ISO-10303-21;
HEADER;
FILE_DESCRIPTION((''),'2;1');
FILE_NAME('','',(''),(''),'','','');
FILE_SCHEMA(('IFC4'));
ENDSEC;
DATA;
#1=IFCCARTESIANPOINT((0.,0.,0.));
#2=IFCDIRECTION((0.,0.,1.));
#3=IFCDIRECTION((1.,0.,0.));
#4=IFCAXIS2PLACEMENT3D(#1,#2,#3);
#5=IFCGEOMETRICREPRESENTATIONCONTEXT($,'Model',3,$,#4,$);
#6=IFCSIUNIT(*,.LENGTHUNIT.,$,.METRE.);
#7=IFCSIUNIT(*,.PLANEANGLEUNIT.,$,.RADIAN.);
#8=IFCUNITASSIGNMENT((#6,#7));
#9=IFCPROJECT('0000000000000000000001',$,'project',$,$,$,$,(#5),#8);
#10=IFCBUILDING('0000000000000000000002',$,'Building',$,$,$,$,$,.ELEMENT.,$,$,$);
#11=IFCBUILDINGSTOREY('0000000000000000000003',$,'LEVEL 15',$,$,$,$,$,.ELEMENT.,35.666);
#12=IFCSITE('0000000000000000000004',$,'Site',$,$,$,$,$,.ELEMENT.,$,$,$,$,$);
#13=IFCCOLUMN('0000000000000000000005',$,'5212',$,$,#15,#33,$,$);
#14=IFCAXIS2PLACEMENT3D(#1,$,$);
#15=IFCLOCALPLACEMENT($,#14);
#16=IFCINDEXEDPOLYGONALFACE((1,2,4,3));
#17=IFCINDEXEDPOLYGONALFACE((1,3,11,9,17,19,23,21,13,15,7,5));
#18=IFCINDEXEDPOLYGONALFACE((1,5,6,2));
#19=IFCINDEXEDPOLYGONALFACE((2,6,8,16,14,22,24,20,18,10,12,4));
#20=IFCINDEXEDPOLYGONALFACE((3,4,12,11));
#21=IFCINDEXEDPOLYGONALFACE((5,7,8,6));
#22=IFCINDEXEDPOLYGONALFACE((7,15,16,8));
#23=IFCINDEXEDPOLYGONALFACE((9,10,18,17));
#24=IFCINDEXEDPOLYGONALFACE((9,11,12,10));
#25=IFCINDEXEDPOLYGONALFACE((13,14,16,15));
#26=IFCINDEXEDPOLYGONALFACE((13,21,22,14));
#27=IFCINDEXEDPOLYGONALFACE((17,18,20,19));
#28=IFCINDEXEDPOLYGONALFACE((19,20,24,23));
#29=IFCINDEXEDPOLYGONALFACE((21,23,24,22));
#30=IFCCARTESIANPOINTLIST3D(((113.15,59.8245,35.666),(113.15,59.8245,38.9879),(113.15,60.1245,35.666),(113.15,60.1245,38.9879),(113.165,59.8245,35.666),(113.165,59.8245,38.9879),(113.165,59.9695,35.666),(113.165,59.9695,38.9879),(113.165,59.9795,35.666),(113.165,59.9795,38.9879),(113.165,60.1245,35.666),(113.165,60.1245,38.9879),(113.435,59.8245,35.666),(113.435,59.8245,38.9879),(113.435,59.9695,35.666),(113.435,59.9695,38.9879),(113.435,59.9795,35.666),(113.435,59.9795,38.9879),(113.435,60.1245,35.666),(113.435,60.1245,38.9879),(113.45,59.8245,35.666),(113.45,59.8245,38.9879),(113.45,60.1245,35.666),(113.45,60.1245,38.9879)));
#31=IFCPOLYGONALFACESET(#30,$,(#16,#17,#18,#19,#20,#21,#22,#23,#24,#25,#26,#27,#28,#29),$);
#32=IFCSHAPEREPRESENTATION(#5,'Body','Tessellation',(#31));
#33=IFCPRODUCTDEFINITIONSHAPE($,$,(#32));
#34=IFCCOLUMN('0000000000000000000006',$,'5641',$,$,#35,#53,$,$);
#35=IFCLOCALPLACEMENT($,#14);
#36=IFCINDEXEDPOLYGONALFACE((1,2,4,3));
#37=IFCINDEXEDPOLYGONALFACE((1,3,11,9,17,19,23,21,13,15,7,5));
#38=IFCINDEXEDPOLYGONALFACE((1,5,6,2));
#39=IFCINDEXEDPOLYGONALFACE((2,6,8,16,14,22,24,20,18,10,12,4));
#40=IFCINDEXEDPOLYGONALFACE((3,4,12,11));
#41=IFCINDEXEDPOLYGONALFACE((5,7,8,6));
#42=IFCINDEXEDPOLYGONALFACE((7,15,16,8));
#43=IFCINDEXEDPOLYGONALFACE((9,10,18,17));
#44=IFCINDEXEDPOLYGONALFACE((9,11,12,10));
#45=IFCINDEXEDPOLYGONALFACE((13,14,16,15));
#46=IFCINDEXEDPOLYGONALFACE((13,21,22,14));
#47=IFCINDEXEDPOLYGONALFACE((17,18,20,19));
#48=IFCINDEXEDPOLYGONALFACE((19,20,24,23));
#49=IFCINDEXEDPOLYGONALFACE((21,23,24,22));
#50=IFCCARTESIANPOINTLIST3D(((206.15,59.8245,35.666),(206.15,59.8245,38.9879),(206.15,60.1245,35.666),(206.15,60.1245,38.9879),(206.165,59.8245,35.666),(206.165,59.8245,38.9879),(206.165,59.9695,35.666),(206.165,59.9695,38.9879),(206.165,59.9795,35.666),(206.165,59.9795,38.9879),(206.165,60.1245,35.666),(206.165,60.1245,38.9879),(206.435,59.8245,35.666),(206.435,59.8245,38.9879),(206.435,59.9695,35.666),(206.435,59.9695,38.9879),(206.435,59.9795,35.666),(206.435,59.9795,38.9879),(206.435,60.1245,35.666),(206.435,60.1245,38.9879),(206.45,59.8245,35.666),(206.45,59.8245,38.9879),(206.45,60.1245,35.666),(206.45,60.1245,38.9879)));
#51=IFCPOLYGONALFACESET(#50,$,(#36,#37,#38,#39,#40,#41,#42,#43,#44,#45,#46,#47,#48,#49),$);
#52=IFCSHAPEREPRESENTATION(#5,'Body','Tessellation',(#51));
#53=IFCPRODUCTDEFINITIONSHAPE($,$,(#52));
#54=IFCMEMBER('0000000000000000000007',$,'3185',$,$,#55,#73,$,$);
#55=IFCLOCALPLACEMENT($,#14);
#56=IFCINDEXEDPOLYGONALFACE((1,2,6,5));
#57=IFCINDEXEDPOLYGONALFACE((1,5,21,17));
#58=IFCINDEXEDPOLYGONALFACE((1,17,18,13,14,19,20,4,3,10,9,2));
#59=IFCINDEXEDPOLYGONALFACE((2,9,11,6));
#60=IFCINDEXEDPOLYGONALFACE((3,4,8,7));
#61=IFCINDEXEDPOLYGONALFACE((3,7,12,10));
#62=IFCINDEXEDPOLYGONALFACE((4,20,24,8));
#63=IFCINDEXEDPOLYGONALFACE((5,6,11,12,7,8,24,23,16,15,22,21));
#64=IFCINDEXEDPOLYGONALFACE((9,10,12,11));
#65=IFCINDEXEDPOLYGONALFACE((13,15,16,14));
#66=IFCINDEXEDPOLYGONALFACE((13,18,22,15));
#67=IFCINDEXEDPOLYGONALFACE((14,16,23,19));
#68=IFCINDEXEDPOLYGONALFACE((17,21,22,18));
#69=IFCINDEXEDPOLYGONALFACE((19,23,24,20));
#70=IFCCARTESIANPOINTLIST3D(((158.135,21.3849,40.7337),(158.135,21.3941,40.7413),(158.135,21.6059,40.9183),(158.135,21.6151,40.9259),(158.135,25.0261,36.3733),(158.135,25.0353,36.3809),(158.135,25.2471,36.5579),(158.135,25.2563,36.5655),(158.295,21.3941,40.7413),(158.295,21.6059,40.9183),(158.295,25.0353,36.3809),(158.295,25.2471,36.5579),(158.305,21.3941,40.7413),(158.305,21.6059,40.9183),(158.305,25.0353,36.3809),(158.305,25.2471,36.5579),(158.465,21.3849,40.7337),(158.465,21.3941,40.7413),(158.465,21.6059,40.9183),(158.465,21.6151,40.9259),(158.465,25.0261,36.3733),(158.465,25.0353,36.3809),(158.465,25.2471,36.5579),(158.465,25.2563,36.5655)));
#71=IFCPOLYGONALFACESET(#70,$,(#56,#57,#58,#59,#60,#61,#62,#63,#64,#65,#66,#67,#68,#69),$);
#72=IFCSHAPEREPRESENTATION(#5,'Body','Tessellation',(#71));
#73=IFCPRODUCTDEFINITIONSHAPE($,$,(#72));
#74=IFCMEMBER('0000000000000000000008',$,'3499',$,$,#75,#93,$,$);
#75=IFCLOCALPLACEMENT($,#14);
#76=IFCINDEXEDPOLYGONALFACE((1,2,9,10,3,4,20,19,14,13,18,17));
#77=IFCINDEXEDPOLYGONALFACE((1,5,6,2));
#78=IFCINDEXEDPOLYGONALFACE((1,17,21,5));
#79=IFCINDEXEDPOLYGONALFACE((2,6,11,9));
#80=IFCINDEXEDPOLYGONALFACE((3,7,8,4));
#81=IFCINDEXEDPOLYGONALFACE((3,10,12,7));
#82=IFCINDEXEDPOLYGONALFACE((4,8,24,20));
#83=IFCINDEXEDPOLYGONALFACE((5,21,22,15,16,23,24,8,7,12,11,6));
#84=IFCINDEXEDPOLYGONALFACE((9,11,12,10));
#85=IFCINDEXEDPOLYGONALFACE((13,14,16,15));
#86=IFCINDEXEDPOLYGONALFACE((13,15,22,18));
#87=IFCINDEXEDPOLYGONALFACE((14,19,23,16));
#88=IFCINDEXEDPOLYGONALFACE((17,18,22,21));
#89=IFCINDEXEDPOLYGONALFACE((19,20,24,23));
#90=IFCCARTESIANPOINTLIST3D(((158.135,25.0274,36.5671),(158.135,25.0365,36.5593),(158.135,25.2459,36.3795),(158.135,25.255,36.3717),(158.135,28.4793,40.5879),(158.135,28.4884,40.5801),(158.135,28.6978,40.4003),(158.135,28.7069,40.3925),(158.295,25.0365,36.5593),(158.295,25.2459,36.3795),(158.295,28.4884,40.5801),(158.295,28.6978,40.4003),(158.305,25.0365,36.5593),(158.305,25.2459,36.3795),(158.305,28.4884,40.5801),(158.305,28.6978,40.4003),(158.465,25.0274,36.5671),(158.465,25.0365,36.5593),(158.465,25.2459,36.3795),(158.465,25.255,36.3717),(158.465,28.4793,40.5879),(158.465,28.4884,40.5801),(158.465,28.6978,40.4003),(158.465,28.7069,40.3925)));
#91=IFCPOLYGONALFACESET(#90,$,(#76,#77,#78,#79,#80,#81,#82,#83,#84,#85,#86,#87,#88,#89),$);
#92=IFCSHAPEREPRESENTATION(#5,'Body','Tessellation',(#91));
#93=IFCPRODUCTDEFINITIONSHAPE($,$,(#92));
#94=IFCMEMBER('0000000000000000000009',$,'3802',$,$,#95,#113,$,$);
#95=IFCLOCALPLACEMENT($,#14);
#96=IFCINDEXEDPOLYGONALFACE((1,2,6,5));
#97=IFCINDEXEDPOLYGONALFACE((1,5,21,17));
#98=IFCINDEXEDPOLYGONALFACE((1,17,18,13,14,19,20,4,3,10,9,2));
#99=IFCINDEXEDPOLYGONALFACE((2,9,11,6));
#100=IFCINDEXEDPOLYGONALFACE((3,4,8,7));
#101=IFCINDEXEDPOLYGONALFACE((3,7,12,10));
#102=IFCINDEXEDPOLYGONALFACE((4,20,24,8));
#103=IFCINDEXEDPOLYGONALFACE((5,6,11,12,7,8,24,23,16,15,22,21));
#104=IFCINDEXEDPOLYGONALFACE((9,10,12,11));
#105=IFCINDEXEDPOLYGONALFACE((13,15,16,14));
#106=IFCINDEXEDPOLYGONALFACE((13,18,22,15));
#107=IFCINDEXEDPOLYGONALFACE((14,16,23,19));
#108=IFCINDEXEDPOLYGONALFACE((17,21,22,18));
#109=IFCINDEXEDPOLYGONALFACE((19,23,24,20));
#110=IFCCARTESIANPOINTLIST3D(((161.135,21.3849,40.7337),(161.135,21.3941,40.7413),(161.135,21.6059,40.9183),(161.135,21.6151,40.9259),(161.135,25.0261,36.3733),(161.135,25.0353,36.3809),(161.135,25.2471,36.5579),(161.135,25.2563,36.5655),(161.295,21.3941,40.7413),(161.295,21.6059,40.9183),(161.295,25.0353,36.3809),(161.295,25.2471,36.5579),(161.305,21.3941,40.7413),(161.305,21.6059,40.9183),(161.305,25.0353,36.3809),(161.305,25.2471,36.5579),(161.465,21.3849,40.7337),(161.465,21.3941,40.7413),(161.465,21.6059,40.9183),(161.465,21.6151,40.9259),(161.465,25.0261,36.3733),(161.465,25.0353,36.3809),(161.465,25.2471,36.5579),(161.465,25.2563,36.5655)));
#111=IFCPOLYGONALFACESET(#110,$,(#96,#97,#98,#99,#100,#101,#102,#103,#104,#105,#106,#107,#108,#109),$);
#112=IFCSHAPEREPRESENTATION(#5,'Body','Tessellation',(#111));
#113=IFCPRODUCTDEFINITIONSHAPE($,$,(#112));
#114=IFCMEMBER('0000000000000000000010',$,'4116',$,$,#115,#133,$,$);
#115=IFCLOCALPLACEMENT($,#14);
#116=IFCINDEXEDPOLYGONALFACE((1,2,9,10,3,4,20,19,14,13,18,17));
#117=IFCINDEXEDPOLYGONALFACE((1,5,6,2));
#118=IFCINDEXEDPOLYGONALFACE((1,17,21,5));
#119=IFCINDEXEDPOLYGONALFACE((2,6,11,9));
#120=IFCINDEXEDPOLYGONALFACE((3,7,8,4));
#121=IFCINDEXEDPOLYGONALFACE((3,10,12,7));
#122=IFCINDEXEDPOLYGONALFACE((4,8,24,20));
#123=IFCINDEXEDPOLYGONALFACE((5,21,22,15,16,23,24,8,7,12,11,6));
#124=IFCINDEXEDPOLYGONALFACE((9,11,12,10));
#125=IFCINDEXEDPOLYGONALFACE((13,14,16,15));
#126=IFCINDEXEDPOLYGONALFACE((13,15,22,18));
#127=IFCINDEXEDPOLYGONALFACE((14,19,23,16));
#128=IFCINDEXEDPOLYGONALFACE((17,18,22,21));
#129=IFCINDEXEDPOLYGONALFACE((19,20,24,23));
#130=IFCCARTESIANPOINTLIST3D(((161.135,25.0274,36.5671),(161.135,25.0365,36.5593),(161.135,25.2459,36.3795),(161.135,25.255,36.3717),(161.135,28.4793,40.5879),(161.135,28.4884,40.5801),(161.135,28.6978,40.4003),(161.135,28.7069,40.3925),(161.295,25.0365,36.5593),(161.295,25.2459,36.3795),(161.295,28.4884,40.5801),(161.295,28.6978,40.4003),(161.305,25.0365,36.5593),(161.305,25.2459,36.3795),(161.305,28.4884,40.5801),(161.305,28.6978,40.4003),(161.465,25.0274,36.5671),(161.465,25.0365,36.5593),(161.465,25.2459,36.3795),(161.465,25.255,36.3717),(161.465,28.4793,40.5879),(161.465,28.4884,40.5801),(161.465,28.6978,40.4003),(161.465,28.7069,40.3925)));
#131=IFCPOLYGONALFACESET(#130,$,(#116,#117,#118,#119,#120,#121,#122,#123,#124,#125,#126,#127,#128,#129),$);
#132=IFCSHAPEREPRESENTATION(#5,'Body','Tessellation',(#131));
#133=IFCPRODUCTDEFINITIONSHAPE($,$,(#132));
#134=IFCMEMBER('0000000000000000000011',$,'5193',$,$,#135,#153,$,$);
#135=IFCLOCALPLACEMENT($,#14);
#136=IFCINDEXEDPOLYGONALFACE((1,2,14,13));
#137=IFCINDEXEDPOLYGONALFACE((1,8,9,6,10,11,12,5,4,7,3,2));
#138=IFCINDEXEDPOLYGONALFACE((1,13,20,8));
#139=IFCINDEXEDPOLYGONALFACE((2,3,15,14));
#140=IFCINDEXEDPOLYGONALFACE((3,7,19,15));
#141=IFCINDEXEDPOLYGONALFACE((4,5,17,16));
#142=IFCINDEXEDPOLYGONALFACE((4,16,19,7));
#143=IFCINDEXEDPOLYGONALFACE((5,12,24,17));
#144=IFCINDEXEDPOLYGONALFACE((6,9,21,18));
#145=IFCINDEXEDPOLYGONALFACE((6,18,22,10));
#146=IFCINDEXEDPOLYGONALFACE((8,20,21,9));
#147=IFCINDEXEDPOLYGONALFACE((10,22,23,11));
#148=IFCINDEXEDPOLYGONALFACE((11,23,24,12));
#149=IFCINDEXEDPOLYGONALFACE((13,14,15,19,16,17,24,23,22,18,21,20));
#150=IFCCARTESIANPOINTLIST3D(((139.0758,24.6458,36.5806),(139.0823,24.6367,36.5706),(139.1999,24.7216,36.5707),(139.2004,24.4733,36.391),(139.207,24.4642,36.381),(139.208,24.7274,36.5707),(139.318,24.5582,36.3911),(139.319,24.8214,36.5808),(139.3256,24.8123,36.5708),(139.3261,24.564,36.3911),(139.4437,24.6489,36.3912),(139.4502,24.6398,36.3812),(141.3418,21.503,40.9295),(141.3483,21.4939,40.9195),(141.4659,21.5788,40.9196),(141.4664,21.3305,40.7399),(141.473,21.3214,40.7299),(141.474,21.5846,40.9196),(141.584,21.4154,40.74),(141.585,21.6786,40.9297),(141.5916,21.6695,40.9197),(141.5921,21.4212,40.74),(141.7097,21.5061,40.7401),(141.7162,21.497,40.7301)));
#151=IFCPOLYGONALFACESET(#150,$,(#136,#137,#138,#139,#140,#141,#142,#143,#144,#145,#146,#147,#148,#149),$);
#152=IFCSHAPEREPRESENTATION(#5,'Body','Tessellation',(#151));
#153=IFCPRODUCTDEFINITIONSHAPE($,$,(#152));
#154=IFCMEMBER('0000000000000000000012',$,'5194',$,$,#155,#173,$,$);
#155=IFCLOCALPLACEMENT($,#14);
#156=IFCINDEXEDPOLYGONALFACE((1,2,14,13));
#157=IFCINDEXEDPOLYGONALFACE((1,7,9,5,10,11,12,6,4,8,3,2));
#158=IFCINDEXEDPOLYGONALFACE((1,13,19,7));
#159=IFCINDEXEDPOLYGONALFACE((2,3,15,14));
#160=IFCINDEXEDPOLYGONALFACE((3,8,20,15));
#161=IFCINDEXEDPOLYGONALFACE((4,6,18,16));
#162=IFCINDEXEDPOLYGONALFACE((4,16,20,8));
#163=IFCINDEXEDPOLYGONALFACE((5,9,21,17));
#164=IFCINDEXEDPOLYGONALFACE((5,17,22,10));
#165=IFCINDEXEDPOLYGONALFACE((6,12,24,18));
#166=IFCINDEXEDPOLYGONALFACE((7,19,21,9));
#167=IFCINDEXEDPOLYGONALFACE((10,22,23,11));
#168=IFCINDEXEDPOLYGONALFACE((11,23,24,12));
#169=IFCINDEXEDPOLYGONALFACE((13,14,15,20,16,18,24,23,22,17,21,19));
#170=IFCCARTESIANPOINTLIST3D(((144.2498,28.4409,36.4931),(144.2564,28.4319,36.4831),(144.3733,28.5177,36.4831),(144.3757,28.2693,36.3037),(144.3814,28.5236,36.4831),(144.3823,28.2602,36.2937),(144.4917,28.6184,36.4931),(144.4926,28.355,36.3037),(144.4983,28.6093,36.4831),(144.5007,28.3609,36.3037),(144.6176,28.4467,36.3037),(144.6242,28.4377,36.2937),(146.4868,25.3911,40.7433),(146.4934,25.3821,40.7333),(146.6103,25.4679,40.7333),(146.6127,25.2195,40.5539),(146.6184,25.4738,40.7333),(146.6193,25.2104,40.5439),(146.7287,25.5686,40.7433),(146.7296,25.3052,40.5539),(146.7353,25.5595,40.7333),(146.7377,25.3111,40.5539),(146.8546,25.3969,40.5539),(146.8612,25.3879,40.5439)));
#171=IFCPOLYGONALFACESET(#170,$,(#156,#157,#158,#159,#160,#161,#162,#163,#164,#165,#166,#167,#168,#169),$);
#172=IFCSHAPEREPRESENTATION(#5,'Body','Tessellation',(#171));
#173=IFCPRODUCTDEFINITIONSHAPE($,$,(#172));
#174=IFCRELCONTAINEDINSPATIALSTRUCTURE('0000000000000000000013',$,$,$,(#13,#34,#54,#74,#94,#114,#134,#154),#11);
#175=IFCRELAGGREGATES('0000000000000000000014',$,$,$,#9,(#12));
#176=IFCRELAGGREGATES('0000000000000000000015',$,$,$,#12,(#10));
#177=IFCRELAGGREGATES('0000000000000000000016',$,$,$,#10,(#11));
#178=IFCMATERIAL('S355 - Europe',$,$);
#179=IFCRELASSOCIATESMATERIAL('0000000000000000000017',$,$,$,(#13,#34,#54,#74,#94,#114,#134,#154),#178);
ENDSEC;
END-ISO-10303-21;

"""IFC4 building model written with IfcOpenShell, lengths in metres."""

from ifc_helpers import new_model, si_unit, frame, origin_with_axes, origin_2d_with_axis, place, context, project, spatial, i_section, extrude, material, material_profile, profile_set, profile_usage, element, save


model = new_model("IFC4")

# Units and contexts
model_context = context("Model", 3, world=origin_with_axes())
ifc_project = project(units=[si_unit("LENGTHUNIT", "METRE"), si_unit("PLANEANGLEUNIT", "RADIAN")], contexts=[model_context])

# Site, building, storey
site = spatial("IfcSite", under=ifc_project, Name="Site", CompositionType="ELEMENT")
building = spatial("IfcBuilding", under=site, Name="Building", CompositionType="ELEMENT")
storey = spatial("IfcBuildingStorey", under=building, Name="LEVEL 15", CompositionType="ELEMENT", Elevation=35.666)

# Columns
ifc_material = material(Name="S355 - Europe")
ifc_material_profile_1 = material_profile(ifc_material, i_section(OverallWidth=0.3, OverallDepth=0.3, WebThickness=0.01, FlangeThickness=0.015, at=origin_2d_with_axis()))
ifc_profile_set_1 = profile_set([ifc_material_profile_1])
ifc_profile_usage_1 = profile_usage(ifc_profile_set_1, cardinal=10)
column_1_placement = place(None, frame((113.3, 59.9745, 35.666), z_axis=(0.0, 0.0, 1.0), x_axis=(0.0, -1.0, 0.0)))
element("IfcColumn", 1, at=column_1_placement, inside=storey, material=ifc_profile_usage_1, Name="5212", context=model_context, shape_type="SweptSolid", body=[
    extrude(i_section(OverallWidth=0.3, OverallDepth=0.3, WebThickness=0.01, FlangeThickness=0.015, at=origin_2d_with_axis()), origin_with_axes(), (0.0, 0.0, 1.0), 3.3219),
])
ifc_material_profile_2 = material_profile(ifc_material, i_section(OverallWidth=0.3, OverallDepth=0.3, WebThickness=0.01, FlangeThickness=0.015, at=origin_2d_with_axis()))
ifc_profile_set_2 = profile_set([ifc_material_profile_2])
ifc_profile_usage_2 = profile_usage(ifc_profile_set_2, cardinal=10)
column_2_placement = place(None, frame((206.3, 59.9745, 35.666), z_axis=(0.0, 0.0, 1.0), x_axis=(0.0, -1.0, 0.0)))
element("IfcColumn", 2, at=column_2_placement, inside=storey, material=ifc_profile_usage_2, Name="5641", context=model_context, shape_type="SweptSolid", body=[
    extrude(i_section(OverallWidth=0.3, OverallDepth=0.3, WebThickness=0.01, FlangeThickness=0.015, at=origin_2d_with_axis()), origin_with_axes(), (0.0, 0.0, 1.0), 3.3219),
])

# Members
ifc_material_profile_3 = material_profile(ifc_material, i_section(OverallWidth=0.33, OverallDepth=0.3, WebThickness=0.01, FlangeThickness=0.012, at=origin_2d_with_axis()))
ifc_profile_set_3 = profile_set([ifc_material_profile_3])
ifc_profile_usage_3 = profile_usage(ifc_profile_set_3, cardinal=10)
member_1_placement = place(None, frame((158.3, 21.5, 40.8298), z_axis=(0.0, 0.640967, -0.767569), x_axis=(-1.0, 0.0, 0.0)))
element("IfcMember", 3, at=member_1_placement, inside=storey, material=ifc_profile_usage_3, Name="3185", context=model_context, shape_type="SweptSolid", body=[
    extrude(i_section(OverallWidth=0.33, OverallDepth=0.3, WebThickness=0.01, FlangeThickness=0.012, at=origin_2d_with_axis()), origin_with_axes(), (0.0, 0.0, 1.0), 5.6808),
])
ifc_material_profile_4 = material_profile(ifc_material, i_section(OverallWidth=0.33, OverallDepth=0.3, WebThickness=0.01, FlangeThickness=0.012, at=origin_2d_with_axis()))
ifc_profile_set_4 = profile_set([ifc_material_profile_4])
ifc_profile_usage_4 = profile_usage(ifc_profile_set_4, cardinal=10)
member_2_placement = place(None, frame((158.3, 25.1412, 36.4694), z_axis=(0.0, 0.651389, 0.758744), x_axis=(-1.0, 0.0, 0.0)))
element("IfcMember", 4, at=member_2_placement, inside=storey, material=ifc_profile_usage_4, Name="3499", context=model_context, shape_type="SweptSolid", body=[
    extrude(i_section(OverallWidth=0.33, OverallDepth=0.3, WebThickness=0.01, FlangeThickness=0.012, at=origin_2d_with_axis()), origin_with_axes(), (0.0, 0.0, 1.0), 5.2993),
])
ifc_material_profile_5 = material_profile(ifc_material, i_section(OverallWidth=0.33, OverallDepth=0.3, WebThickness=0.01, FlangeThickness=0.012, at=origin_2d_with_axis()))
ifc_profile_set_5 = profile_set([ifc_material_profile_5])
ifc_profile_usage_5 = profile_usage(ifc_profile_set_5, cardinal=10)
member_3_placement = place(None, frame((161.3, 21.5, 40.8298), z_axis=(0.0, 0.640967, -0.767569), x_axis=(-1.0, 0.0, 0.0)))
element("IfcMember", 5, at=member_3_placement, inside=storey, material=ifc_profile_usage_5, Name="3802", context=model_context, shape_type="SweptSolid", body=[
    extrude(i_section(OverallWidth=0.33, OverallDepth=0.3, WebThickness=0.01, FlangeThickness=0.012, at=origin_2d_with_axis()), origin_with_axes(), (0.0, 0.0, 1.0), 5.6808),
])
ifc_material_profile_6 = material_profile(ifc_material, i_section(OverallWidth=0.33, OverallDepth=0.3, WebThickness=0.01, FlangeThickness=0.012, at=origin_2d_with_axis()))
ifc_profile_set_6 = profile_set([ifc_material_profile_6])
ifc_profile_usage_6 = profile_usage(ifc_profile_set_6, cardinal=10)
member_4_placement = place(None, frame((161.3, 25.1412, 36.4694), z_axis=(0.0, 0.651389, 0.758744), x_axis=(-1.0, 0.0, 0.0)))
element("IfcMember", 6, at=member_4_placement, inside=storey, material=ifc_profile_usage_6, Name="4116", context=model_context, shape_type="SweptSolid", body=[
    extrude(i_section(OverallWidth=0.33, OverallDepth=0.3, WebThickness=0.01, FlangeThickness=0.012, at=origin_2d_with_axis()), origin_with_axes(), (0.0, 0.0, 1.0), 5.2993),
])
ifc_material_profile_7 = material_profile(ifc_material, i_section(OverallWidth=0.3, OverallDepth=0.3, WebThickness=0.01, FlangeThickness=0.015, at=origin_2d_with_axis()))
ifc_profile_set_7 = profile_set([ifc_material_profile_7])
ifc_profile_usage_7 = profile_usage(ifc_profile_set_7, cardinal=10)
member_5_placement = place(None, frame((139.263, 24.6428, 36.4809), z_axis=(0.389046, -0.539582, 0.746656), x_axis=(0.810475, 0.585773, 0.0)))
element("IfcMember", 7, at=member_5_placement, inside=storey, material=ifc_profile_usage_7, Name="5193", context=model_context, shape_type="SweptSolid", body=[
    extrude(i_section(OverallWidth=0.3, OverallDepth=0.3, WebThickness=0.01, FlangeThickness=0.015, at=origin_2d_with_axis()), origin_with_axes(), (0.0, 0.0, 1.0), 5.8245),
])
ifc_material_profile_8 = material_profile(ifc_material, i_section(OverallWidth=0.3, OverallDepth=0.3, WebThickness=0.01, FlangeThickness=0.015, at=origin_2d_with_axis()))
ifc_profile_set_8 = profile_set([ifc_material_profile_8])
ifc_profile_usage_8 = profile_usage(ifc_profile_set_8, cardinal=10)
member_6_placement = place(None, frame((144.437, 28.4393, 36.3934), z_axis=(0.393185, -0.536046, 0.747034), x_axis=(0.806353, 0.591435, 0.0)))
element("IfcMember", 8, at=member_6_placement, inside=storey, material=ifc_profile_usage_8, Name="5194", context=model_context, shape_type="SweptSolid", body=[
    extrude(i_section(OverallWidth=0.3, OverallDepth=0.3, WebThickness=0.01, FlangeThickness=0.015, at=origin_2d_with_axis()), origin_with_axes(), (0.0, 0.0, 1.0), 5.6894),
])

save(model, "model.ifc")
